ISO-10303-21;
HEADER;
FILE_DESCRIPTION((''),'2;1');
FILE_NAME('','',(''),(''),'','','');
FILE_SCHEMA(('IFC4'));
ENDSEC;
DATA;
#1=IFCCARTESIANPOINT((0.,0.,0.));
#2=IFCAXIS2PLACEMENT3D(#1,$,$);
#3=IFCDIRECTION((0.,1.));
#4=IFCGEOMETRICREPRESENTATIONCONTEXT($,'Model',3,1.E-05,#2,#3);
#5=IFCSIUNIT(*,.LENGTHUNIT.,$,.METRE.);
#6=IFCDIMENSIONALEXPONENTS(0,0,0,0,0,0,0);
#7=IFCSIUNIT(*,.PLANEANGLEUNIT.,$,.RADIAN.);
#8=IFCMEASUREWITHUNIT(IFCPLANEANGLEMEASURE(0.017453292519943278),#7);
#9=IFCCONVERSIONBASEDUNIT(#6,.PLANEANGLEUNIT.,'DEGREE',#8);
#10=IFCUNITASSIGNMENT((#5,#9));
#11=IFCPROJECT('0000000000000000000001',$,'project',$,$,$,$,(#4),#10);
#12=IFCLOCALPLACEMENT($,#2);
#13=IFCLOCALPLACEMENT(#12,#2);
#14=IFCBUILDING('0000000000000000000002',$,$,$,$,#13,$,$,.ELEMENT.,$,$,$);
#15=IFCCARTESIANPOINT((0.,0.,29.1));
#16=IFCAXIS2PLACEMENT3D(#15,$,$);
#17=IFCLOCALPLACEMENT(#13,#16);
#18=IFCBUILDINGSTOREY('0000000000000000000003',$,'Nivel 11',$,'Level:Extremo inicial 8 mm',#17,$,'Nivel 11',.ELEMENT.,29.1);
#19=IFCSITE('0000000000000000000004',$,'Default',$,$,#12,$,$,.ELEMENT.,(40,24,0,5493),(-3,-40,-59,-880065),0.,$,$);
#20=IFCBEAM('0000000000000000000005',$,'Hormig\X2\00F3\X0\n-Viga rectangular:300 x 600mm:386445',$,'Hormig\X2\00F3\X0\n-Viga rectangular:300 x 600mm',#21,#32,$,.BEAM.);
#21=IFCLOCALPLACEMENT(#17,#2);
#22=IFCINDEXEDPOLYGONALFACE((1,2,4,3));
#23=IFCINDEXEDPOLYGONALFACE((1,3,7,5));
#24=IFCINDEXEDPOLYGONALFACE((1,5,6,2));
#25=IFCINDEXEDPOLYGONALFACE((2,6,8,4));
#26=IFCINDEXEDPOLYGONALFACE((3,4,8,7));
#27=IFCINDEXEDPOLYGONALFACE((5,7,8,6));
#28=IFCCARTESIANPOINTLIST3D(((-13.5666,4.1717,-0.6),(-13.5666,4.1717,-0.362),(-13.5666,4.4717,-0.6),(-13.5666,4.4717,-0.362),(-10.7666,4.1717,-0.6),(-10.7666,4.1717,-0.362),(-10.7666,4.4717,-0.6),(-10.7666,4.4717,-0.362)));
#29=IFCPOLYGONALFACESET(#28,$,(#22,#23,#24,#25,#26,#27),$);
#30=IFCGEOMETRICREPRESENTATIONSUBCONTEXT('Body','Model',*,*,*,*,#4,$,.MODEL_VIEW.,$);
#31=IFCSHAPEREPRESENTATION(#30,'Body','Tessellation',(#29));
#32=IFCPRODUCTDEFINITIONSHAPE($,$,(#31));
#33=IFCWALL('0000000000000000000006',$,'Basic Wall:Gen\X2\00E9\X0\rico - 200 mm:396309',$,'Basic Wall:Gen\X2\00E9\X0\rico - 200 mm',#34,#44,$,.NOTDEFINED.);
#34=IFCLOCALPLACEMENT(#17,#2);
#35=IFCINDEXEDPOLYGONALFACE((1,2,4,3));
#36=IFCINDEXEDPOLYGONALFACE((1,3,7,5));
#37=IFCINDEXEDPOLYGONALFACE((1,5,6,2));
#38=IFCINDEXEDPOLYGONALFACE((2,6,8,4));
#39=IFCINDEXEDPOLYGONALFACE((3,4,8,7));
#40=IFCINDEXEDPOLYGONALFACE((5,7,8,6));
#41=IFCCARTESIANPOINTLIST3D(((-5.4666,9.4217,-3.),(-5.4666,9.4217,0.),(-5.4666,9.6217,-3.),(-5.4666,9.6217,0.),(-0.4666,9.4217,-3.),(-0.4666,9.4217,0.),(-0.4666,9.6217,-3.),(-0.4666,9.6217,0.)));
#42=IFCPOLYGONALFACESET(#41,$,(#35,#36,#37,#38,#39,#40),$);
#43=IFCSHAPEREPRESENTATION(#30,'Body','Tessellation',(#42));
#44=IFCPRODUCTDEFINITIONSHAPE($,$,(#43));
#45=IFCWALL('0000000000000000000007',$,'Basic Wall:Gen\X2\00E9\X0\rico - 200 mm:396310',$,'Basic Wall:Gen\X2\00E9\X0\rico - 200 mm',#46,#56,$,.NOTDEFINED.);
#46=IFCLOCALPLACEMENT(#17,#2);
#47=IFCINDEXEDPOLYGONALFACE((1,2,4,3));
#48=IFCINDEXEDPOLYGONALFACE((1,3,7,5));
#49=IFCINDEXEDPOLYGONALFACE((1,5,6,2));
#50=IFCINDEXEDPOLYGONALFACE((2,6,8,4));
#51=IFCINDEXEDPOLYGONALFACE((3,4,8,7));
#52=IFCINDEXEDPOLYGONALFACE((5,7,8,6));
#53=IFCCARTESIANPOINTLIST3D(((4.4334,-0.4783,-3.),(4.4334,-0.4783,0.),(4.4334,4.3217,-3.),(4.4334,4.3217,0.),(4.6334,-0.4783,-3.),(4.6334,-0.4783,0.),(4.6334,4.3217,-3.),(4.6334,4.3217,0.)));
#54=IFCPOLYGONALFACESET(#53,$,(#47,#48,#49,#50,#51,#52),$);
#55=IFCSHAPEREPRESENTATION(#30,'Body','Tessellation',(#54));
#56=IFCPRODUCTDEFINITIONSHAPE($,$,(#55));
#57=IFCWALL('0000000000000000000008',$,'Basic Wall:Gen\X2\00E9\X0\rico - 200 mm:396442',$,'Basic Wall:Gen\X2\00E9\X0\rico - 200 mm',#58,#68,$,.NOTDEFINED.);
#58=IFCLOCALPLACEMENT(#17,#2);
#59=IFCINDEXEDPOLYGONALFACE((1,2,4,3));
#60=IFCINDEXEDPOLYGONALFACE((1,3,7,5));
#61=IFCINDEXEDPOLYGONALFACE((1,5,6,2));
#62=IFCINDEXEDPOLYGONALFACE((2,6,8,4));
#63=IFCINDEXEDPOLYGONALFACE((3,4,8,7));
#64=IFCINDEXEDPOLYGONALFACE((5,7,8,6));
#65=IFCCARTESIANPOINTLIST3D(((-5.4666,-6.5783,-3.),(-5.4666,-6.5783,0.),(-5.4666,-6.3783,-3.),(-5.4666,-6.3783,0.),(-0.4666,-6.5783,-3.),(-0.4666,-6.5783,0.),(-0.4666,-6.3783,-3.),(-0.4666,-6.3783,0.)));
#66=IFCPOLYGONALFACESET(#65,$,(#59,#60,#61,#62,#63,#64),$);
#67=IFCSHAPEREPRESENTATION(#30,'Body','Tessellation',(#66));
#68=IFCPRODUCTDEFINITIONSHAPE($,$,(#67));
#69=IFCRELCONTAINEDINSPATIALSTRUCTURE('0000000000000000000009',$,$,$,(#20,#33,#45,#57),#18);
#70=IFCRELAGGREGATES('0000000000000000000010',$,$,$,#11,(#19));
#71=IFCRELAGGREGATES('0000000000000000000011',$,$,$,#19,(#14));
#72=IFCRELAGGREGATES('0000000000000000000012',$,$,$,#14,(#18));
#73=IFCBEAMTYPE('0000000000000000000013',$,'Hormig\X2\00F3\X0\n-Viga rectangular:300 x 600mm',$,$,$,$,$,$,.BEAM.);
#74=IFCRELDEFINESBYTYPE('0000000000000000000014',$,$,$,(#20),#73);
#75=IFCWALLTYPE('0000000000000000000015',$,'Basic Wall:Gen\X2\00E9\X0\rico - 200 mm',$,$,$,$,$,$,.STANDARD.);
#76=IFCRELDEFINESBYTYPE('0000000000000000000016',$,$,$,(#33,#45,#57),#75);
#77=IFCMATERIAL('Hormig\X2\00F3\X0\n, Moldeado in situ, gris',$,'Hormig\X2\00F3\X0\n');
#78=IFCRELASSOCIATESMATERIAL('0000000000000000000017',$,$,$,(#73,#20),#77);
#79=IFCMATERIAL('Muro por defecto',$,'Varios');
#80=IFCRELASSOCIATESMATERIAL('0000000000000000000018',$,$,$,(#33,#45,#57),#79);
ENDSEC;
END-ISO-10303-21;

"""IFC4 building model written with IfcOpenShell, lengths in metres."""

from ifc_helpers import new_model, entity, si_unit, converted_unit, direction, frame, origin, place, context, subcontext, project, spatial, indexed_curve, outline, extrude, source, transform, mapped, material, type_object, type_shapes, element, save


model = new_model("IFC4")

# Units and contexts
model_context = context("Model", 3, precision=1e-05, world=origin(), true_north=direction((0.0, 1.0)))
body_context = subcontext(model_context, "Body", "Model", "MODEL_VIEW")
ifc_project = project(units=[si_unit("LENGTHUNIT", "METRE"), converted_unit("PLANEANGLEUNIT", "DEGREE", entity("IfcPlaneAngleMeasure", 0.017453292519943278), si_unit("PLANEANGLEUNIT", "RADIAN"), dimensions=[0, 0, 0, 0, 0, 0, 0])], contexts=[model_context])

# Site, building, storey
site_placement = place(None, origin())
site = spatial("IfcSite", under=ifc_project, at=site_placement, Name="Default", CompositionType="ELEMENT", RefLatitude=(40, 24, 0, 5493), RefLongitude=(-3, -40, -59, -880065), RefElevation=0.0)
building_placement = place(site_placement, origin())
building = spatial("IfcBuilding", under=site, at=building_placement, CompositionType="ELEMENT")
storey_placement = place(building_placement, frame((0.0, 0.0, 29.1)))
storey = spatial("IfcBuildingStorey", under=building, at=storey_placement, Name="Nivel 11", ObjectType="Level:Extremo inicial 8 mm", LongName="Nivel 11", CompositionType="ELEMENT", Elevation=29.1)

# Shared definitions
ifc_material_1 = material(Name="Hormigón, Moldeado in situ, gris", Category="Hormigón")

# Beam
beam_type_1 = type_object("IfcBeamType", Name="Hormigón-Viga rectangular:300 x 600mm", PredefinedType="BEAM", material=ifc_material_1)
shared_shape_1 = source(origin(), body_context, "Body", "SweptSolid", [
    extrude(outline(indexed_curve([(-0.119, -0.15), (0.119, -0.15), (0.119, 0.15), (-0.119, 0.15), (-0.119, -0.15)], self_intersect=False)), frame((-10.7666, 4.3217, 28.619), z_axis=(-1.0, 0.0, 0.0), x_axis=(0.0, 0.0, -1.0)), (0.0, 0.0, 1.0), 2.8),
])
type_shapes(beam_type_1, [shared_shape_1])
beam_1_placement = place(storey_placement, frame((0.0, 0.0, -29.1)))
element("IfcBeam", 1, at=beam_1_placement, inside=storey, type_object=beam_type_1, material=ifc_material_1, Name="Hormigón-Viga rectangular:300 x 600mm:386445", ObjectType="Hormigón-Viga rectangular:300 x 600mm", PredefinedType="BEAM", context=body_context, shape_type="MappedRepresentation", body=[
    mapped(shared_shape_1, transform((0.0, 0.0, 0.0), scale=1.0)),
])

# Walls
ifc_material_2 = material(Name="Muro por defecto", Category="Varios")
wall_type = type_object("IfcWallType", Name="Basic Wall:Genérico - 200 mm", PredefinedType="STANDARD")
wall_1_placement = place(storey_placement, frame((-5.4666, 9.5217, -3.0)))
element("IfcWall", 2, at=wall_1_placement, inside=storey, type_object=wall_type, material=ifc_material_2, Name="Basic Wall:Genérico - 200 mm:396309", ObjectType="Basic Wall:Genérico - 200 mm", PredefinedType="NOTDEFINED", context=body_context, shape_type="SweptSolid", body=[
    extrude(outline(indexed_curve([(5.0, 0.1), (0.0, 0.1), (0.0, -0.1), (5.0, -0.1), (5.0, 0.1)], self_intersect=False)), origin(), (0.0, 0.0, 1.0), 3.0),
])
wall_2_placement = place(storey_placement, frame((4.5334, 4.3217, -3.0), z_axis=(0.0, 0.0, 1.0), x_axis=(0.0, -1.0, 0.0)))
element("IfcWall", 3, at=wall_2_placement, inside=storey, type_object=wall_type, material=ifc_material_2, Name="Basic Wall:Genérico - 200 mm:396310", ObjectType="Basic Wall:Genérico - 200 mm", PredefinedType="NOTDEFINED", context=body_context, shape_type="SweptSolid", body=[
    extrude(outline(indexed_curve([(4.8, 0.1), (0.0, 0.1), (0.0, -0.1), (4.8, -0.1), (4.8, 0.1)], self_intersect=False)), origin(), (0.0, 0.0, 1.0), 3.0),
])
wall_3_placement = place(storey_placement, frame((-5.4666, -6.4783, -3.0)))
element("IfcWall", 4, at=wall_3_placement, inside=storey, type_object=wall_type, material=ifc_material_2, Name="Basic Wall:Genérico - 200 mm:396442", ObjectType="Basic Wall:Genérico - 200 mm", PredefinedType="NOTDEFINED", context=body_context, shape_type="SweptSolid", body=[
    extrude(outline(indexed_curve([(5.0, 0.1), (0.0, 0.1), (0.0, -0.1), (5.0, -0.1), (5.0, 0.1)], self_intersect=False)), origin(), (0.0, 0.0, 1.0), 3.0),
])

save(model, "model.ifc")
